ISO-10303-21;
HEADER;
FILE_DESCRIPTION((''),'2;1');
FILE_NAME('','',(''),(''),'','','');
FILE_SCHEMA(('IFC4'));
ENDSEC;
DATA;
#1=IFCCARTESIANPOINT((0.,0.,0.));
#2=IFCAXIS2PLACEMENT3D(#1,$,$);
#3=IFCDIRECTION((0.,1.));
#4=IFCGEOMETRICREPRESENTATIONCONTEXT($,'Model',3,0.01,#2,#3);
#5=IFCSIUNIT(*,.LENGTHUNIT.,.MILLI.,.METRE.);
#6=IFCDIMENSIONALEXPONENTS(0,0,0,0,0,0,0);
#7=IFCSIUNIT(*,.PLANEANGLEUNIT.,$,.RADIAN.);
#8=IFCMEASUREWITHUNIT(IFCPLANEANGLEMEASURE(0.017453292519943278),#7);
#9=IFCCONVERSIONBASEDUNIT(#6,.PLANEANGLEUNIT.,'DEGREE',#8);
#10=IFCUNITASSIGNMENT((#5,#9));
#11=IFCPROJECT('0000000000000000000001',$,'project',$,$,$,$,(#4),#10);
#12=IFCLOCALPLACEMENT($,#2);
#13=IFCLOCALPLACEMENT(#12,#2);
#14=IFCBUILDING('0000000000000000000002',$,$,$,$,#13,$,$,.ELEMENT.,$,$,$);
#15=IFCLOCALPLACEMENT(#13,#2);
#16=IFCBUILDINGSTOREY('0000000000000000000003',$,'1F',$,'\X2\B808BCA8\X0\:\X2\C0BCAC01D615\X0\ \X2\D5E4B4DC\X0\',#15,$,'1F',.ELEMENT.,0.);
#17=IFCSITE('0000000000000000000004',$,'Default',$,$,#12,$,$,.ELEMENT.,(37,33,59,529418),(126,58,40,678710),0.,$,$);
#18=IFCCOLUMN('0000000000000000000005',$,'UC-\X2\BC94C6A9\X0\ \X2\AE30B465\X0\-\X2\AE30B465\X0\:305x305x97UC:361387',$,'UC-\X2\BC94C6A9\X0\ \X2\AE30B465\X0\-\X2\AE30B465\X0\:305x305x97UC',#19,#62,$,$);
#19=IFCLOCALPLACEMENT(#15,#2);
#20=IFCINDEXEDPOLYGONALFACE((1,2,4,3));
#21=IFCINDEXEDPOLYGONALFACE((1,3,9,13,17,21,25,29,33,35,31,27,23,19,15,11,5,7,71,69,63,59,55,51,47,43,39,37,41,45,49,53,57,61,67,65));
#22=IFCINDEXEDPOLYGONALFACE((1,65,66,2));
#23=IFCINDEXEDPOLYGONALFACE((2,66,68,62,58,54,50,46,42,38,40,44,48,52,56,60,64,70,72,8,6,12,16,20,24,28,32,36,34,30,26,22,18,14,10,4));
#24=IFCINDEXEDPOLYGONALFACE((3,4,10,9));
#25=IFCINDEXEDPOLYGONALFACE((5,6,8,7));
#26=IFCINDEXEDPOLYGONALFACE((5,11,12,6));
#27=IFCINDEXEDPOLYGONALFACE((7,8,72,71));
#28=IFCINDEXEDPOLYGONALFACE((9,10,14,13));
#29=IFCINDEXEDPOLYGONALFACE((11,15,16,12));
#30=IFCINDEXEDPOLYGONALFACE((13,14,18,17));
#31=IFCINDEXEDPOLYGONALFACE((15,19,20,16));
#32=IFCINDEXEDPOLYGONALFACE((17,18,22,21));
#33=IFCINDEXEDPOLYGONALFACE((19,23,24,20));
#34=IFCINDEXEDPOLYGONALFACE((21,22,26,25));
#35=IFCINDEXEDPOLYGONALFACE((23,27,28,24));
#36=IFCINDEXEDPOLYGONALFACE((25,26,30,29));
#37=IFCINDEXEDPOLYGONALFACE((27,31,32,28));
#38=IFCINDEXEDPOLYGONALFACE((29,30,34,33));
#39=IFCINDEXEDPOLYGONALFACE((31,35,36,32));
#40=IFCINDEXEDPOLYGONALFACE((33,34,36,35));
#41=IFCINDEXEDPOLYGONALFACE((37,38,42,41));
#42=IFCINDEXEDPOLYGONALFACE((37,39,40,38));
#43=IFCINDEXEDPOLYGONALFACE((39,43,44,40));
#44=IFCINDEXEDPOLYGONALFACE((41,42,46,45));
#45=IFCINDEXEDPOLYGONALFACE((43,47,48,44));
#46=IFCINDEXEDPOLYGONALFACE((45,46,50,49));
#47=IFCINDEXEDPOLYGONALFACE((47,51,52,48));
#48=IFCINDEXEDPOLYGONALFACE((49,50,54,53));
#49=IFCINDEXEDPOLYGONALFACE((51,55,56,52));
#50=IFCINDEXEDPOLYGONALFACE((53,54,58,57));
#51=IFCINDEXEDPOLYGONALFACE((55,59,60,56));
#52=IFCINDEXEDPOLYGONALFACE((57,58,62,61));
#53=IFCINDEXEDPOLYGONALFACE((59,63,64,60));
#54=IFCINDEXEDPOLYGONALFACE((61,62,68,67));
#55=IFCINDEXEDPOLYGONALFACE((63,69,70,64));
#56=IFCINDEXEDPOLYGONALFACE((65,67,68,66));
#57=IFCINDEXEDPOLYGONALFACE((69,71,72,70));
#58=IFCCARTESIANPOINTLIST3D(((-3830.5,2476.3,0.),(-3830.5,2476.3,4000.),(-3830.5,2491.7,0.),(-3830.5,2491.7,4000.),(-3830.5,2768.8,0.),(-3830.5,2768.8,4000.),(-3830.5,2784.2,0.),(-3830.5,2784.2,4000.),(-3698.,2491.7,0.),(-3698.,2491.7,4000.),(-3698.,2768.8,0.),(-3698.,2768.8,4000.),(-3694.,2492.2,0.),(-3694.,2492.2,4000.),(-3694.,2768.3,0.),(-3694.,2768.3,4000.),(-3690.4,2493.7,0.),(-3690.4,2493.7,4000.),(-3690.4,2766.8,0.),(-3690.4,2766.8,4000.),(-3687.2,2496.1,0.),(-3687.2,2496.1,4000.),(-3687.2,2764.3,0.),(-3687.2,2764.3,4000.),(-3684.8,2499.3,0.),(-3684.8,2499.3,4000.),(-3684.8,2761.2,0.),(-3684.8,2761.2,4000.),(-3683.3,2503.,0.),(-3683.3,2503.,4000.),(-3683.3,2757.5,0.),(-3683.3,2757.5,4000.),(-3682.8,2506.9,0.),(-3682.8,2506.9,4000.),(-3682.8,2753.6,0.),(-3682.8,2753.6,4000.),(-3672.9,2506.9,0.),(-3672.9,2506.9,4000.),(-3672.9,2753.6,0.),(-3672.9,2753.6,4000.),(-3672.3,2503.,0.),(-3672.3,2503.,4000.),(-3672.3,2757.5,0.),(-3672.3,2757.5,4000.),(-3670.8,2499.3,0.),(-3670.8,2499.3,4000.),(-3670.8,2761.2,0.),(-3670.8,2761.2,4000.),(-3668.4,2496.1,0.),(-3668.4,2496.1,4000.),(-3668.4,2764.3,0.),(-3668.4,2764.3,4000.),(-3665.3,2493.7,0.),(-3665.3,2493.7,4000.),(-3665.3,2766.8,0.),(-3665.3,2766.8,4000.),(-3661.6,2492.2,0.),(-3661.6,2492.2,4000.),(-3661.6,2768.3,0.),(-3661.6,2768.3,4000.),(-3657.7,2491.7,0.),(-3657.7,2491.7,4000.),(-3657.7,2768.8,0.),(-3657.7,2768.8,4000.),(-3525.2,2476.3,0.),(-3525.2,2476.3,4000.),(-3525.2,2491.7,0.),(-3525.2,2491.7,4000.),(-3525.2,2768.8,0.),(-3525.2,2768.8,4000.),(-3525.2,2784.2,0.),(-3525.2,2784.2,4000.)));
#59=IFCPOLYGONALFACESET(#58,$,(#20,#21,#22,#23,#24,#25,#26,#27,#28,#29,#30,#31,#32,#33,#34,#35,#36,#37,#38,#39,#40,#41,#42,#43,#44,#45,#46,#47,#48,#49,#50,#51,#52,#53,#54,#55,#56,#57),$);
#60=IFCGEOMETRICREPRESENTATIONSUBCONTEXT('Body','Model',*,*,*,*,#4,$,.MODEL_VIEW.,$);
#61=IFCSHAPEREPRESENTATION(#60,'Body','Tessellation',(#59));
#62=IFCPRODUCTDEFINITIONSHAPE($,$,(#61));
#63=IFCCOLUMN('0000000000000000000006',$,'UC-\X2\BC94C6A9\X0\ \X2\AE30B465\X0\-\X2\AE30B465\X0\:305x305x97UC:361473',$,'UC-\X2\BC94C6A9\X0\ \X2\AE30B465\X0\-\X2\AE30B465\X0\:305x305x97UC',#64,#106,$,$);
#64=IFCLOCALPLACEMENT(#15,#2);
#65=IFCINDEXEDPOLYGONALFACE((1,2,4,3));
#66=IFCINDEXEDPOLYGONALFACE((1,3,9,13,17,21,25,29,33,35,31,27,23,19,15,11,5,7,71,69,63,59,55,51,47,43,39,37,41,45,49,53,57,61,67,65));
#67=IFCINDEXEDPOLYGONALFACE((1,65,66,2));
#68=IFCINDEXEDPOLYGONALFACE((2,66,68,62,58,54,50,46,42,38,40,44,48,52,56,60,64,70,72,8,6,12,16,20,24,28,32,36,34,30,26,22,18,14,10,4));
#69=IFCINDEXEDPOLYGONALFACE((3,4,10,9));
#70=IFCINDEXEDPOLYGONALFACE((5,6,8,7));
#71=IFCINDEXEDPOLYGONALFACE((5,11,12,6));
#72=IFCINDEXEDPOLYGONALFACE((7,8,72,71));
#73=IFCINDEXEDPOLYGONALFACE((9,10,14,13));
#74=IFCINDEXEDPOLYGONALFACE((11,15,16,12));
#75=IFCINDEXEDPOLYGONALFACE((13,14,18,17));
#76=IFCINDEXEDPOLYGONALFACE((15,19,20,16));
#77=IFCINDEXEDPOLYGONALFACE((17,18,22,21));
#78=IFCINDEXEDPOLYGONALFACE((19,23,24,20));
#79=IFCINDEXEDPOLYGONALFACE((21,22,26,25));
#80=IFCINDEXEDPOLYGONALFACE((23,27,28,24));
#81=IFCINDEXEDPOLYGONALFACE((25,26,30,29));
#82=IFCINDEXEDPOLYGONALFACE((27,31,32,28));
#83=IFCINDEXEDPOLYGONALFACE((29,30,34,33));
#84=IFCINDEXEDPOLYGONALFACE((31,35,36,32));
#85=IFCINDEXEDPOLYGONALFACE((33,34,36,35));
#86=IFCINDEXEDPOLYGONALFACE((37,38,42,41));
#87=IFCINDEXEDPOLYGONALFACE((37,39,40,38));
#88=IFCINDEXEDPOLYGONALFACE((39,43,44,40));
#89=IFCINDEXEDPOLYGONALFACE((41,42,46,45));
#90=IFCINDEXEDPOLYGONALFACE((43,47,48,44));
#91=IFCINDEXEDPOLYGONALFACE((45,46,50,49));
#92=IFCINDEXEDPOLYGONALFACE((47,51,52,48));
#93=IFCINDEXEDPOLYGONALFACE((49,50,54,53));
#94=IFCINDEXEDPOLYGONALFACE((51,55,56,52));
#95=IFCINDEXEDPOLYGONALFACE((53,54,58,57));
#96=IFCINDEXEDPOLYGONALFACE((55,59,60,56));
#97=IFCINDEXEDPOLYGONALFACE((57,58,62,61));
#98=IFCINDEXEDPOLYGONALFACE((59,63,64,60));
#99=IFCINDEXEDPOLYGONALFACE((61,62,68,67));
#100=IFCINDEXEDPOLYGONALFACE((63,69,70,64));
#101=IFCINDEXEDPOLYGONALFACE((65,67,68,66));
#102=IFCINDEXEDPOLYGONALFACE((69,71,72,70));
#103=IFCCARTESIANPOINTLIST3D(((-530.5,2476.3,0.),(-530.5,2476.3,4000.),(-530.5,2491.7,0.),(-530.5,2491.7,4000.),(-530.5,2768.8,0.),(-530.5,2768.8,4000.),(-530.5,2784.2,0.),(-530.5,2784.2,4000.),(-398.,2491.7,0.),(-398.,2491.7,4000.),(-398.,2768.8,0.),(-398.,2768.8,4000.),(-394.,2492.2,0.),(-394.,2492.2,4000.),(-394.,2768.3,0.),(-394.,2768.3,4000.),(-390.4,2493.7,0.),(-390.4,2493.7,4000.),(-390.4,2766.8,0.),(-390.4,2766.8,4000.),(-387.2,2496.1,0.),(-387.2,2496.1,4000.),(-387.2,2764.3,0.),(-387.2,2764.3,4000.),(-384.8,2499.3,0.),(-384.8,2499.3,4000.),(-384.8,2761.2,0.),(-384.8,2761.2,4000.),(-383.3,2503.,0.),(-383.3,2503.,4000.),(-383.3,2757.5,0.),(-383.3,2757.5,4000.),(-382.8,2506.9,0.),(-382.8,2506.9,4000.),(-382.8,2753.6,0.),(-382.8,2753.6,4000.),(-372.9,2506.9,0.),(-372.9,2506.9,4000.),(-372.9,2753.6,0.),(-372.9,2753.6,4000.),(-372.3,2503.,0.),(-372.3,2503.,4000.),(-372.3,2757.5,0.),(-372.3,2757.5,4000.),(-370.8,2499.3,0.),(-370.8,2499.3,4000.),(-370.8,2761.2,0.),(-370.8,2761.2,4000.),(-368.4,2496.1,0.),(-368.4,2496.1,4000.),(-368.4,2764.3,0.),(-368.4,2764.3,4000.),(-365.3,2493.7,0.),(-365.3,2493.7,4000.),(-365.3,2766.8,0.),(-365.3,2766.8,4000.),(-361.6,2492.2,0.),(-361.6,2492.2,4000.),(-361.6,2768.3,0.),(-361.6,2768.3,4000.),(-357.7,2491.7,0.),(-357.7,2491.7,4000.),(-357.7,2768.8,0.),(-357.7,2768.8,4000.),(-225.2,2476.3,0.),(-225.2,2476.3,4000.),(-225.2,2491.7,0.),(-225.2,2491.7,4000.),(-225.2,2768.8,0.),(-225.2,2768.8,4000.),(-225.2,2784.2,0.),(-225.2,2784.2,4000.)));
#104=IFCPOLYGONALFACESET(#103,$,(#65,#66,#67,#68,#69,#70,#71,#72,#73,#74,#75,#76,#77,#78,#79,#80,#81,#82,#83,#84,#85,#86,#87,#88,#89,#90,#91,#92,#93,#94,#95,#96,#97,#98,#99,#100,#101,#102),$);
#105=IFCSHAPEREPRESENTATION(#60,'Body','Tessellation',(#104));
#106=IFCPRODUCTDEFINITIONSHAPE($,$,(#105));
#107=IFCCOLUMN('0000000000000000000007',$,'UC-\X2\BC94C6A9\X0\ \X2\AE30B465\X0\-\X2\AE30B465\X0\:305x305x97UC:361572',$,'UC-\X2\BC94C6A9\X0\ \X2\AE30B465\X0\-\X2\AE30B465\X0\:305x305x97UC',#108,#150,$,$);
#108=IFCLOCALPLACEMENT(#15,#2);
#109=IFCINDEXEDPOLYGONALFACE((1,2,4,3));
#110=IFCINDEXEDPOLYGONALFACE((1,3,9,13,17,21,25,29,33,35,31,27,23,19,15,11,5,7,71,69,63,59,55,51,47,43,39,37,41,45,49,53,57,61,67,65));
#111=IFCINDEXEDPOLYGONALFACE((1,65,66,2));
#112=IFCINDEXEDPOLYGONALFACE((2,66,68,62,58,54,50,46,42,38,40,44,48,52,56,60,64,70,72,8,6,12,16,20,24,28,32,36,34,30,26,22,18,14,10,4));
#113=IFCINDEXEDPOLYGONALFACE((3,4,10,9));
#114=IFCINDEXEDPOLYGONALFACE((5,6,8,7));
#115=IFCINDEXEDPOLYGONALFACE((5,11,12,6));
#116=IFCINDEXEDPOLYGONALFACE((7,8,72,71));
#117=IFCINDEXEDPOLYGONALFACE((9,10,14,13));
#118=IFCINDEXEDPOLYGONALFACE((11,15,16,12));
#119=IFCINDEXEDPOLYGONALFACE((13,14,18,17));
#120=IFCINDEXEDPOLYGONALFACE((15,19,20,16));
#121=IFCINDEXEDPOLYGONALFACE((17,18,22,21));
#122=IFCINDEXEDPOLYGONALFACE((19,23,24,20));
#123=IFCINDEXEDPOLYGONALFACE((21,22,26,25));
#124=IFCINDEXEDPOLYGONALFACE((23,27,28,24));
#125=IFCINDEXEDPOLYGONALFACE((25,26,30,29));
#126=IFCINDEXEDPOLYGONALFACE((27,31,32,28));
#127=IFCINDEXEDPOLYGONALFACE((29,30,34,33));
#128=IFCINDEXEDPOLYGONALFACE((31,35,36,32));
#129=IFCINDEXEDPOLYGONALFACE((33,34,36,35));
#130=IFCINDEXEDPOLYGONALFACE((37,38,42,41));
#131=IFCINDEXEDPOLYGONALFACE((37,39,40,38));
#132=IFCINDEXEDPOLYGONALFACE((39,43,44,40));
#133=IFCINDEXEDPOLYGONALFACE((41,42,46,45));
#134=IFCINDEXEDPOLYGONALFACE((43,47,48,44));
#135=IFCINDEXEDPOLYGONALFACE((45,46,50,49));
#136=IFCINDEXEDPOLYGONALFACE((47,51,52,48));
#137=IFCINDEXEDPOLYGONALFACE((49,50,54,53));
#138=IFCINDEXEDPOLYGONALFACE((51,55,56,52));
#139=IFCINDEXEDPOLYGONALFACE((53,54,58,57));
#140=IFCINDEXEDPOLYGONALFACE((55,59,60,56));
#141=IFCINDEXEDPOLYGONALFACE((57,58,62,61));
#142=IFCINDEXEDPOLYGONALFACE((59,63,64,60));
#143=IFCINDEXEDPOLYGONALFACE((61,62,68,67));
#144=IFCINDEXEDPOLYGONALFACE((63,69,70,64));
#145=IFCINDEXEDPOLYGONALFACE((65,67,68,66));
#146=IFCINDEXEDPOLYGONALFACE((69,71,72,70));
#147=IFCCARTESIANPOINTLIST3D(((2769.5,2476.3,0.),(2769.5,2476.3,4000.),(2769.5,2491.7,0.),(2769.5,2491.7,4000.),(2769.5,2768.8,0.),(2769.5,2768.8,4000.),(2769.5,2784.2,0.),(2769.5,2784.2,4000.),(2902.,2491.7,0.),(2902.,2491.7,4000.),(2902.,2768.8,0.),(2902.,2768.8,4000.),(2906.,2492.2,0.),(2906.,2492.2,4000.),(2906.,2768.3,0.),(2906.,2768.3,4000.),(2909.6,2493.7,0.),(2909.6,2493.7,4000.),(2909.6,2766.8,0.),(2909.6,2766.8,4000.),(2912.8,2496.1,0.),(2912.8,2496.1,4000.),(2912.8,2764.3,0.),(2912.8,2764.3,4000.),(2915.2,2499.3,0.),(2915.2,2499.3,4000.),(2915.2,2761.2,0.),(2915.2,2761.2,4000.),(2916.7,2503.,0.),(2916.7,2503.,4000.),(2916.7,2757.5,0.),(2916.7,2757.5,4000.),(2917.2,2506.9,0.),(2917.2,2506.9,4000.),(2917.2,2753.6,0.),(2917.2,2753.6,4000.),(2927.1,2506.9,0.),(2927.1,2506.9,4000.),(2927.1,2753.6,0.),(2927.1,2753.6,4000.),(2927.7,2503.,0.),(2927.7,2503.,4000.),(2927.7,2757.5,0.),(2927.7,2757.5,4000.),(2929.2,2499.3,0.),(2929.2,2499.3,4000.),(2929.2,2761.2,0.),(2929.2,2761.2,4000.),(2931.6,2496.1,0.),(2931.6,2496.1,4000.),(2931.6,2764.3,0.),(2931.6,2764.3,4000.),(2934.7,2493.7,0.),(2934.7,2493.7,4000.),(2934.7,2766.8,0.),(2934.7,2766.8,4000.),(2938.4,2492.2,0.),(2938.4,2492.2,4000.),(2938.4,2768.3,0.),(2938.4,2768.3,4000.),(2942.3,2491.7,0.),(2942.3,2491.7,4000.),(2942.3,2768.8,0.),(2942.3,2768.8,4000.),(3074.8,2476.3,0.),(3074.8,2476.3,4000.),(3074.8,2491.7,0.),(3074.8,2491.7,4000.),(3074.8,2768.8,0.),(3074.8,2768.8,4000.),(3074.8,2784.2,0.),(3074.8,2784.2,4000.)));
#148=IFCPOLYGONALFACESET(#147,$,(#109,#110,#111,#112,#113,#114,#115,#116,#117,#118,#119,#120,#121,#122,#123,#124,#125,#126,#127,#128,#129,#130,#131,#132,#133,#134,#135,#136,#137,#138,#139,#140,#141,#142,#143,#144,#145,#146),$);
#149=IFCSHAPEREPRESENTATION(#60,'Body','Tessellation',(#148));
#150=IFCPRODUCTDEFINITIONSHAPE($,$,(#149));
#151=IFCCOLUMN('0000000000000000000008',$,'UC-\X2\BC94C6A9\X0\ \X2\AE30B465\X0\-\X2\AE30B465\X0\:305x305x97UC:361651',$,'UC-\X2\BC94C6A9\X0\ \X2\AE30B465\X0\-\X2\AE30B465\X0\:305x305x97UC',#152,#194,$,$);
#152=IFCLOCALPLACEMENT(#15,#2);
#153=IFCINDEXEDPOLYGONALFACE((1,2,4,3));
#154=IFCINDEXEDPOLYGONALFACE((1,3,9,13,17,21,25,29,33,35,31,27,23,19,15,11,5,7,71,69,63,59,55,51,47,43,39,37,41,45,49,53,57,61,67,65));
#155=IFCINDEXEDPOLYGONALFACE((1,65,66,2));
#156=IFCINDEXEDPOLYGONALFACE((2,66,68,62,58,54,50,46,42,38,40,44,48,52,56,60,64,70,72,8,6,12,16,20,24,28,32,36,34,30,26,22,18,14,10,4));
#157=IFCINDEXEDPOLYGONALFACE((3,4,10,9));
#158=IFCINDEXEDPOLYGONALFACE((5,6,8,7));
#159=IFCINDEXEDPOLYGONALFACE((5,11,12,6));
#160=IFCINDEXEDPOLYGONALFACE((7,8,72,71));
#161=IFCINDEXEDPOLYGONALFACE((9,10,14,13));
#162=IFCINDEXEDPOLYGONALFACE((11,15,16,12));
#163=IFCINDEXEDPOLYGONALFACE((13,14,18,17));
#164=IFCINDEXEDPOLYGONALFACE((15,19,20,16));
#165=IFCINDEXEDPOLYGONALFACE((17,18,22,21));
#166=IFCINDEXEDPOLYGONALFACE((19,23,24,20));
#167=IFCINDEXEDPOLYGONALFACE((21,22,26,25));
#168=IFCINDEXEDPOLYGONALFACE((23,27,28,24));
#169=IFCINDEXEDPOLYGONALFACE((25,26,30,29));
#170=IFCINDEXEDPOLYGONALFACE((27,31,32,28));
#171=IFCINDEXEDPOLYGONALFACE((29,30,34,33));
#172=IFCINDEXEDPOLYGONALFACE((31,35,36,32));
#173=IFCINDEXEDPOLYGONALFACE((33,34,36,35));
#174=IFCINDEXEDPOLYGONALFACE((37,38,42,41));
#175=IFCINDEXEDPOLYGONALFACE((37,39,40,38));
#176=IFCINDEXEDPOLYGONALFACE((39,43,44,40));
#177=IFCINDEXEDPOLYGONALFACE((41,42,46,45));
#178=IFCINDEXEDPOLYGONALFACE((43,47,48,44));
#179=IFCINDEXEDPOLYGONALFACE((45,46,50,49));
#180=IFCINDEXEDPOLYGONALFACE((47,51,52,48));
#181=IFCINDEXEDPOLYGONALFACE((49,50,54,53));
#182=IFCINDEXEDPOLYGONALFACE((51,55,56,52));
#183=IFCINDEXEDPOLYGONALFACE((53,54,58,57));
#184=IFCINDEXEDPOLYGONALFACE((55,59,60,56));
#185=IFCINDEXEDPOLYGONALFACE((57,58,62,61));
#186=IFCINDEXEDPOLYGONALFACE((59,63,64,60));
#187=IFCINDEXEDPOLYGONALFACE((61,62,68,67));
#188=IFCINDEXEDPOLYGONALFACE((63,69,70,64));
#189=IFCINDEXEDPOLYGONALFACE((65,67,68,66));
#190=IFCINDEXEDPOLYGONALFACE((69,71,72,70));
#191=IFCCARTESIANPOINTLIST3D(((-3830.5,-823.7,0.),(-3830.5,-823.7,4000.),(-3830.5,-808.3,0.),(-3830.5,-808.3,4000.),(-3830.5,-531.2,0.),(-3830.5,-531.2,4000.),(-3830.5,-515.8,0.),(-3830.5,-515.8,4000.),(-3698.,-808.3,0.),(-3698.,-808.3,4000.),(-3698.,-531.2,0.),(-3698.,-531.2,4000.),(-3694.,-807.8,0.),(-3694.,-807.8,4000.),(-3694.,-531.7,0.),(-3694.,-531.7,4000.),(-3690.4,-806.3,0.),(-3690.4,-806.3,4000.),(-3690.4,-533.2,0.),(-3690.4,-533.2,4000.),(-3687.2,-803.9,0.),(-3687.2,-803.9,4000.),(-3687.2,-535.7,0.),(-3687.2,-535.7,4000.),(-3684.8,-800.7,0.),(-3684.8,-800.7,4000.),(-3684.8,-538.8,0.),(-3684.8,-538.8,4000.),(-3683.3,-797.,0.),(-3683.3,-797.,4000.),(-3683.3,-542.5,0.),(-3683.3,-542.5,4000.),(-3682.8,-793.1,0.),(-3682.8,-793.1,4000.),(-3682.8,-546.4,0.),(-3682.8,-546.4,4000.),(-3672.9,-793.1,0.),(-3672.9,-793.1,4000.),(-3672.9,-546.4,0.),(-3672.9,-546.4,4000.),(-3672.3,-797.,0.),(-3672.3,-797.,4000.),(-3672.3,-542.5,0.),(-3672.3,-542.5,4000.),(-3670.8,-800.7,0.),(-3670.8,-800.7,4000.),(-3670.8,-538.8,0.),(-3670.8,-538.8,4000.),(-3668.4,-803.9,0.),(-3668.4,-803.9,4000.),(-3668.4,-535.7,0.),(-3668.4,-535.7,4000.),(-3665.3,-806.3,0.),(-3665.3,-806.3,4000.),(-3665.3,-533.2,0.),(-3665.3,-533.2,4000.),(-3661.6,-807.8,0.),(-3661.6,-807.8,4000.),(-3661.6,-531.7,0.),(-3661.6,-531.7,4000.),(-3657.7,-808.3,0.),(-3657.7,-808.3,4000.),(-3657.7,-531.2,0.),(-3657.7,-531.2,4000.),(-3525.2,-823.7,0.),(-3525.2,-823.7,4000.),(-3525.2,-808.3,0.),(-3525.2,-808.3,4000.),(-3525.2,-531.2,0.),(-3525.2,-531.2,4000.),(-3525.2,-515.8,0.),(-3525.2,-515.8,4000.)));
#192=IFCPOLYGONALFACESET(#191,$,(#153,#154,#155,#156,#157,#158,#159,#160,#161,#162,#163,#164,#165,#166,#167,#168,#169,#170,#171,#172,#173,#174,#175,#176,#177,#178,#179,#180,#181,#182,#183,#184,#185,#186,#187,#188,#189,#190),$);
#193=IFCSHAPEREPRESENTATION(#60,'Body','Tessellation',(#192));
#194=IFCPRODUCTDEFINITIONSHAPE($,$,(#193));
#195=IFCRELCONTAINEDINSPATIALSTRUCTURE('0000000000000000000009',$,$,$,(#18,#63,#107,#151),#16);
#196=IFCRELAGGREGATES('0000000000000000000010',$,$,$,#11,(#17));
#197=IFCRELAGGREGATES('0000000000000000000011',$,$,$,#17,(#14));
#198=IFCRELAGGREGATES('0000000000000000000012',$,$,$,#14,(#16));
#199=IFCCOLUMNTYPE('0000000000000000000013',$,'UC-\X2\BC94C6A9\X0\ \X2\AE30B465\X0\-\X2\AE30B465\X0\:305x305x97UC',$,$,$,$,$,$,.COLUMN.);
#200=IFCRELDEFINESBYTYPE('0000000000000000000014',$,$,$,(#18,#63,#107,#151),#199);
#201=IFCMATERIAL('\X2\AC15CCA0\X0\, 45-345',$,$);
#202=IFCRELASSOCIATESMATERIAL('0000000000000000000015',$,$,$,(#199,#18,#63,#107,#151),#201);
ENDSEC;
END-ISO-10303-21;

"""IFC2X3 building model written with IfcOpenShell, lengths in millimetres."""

from ifc_helpers import new_model, entity, si_unit, converted_unit, direction, frame, origin, origin_2d_with_axis, place, context, subcontext, project, spatial, i_section, extrude, source, transform, mapped, material, type_object, type_shapes, element, save


model = new_model("IFC2X3")

# Units and contexts
model_context = context("Model", 3, precision=0.01, world=origin(), true_north=direction((0.0, 1.0)))
body_context = subcontext(model_context, "Body", "Model", "MODEL_VIEW")
ifc_project = project(units=[si_unit("LENGTHUNIT", "METRE", prefix="MILLI"), converted_unit("PLANEANGLEUNIT", "DEGREE", entity("IfcPlaneAngleMeasure", 0.017453292519943278), si_unit("PLANEANGLEUNIT", "RADIAN"), dimensions=[0, 0, 0, 0, 0, 0, 0])], contexts=[model_context])

# Site, building, storey
site_placement = place(None, origin())
site = spatial("IfcSite", under=ifc_project, at=site_placement, Name="Default", CompositionType="ELEMENT", RefLatitude=(37, 33, 59, 529418), RefLongitude=(126, 58, 40, 678710), RefElevation=0.0)
building_placement = place(site_placement, origin())
building = spatial("IfcBuilding", under=site, at=building_placement, CompositionType="ELEMENT")
storey_placement = place(building_placement, origin())
storey = spatial("IfcBuildingStorey", under=building, at=storey_placement, Name="1F", ObjectType="레벨:삼각형 헤드", LongName="1F", CompositionType="ELEMENT", Elevation=0.0)

# Columns
ifc_material_1 = material(Name="강철, 45-345")
column_type = type_object("IfcColumnType", Name="UC-범용 기둥-기둥:305x305x97UC", PredefinedType="COLUMN", material=ifc_material_1)
shared_shape = source(origin(), body_context, "Body", "SweptSolid", [
    extrude(i_section(OverallWidth=305.3, OverallDepth=307.9, WebThickness=9.9, FlangeThickness=15.4, FilletRadius=15.2, at=origin_2d_with_axis()), frame((0.0, 0.0, 0.0), z_axis=(0.0, 0.0, 1.0), x_axis=(-1.0, 0.0, 0.0)), (0.0, 0.0, 1.0), 4000.0),
])
type_shapes(column_type, [shared_shape])
for number, where, name in (
    (1, (-3677.8, 2630.2, 0.0), "UC-범용 기둥-기둥:305x305x97UC:361387"),
    (2, (-377.8, 2630.2, 0.0), "UC-범용 기둥-기둥:305x305x97UC:361473"),
    (3, (2922.2, 2630.2, 0.0), "UC-범용 기둥-기둥:305x305x97UC:361572"),
    (4, (-3677.8, -669.8, 0.0), "UC-범용 기둥-기둥:305x305x97UC:361651"),
):
    element("IfcColumn", number, at=place(storey_placement, frame(where)), inside=storey, type_object=column_type, material=ifc_material_1, Name=name, ObjectType="UC-범용 기둥-기둥:305x305x97UC", context=body_context, shape_type="MappedRepresentation", body=[
        mapped(shared_shape, transform((0.0, 0.0, 0.0), scale=1.0)),
    ])

save(model, "model.ifc")
